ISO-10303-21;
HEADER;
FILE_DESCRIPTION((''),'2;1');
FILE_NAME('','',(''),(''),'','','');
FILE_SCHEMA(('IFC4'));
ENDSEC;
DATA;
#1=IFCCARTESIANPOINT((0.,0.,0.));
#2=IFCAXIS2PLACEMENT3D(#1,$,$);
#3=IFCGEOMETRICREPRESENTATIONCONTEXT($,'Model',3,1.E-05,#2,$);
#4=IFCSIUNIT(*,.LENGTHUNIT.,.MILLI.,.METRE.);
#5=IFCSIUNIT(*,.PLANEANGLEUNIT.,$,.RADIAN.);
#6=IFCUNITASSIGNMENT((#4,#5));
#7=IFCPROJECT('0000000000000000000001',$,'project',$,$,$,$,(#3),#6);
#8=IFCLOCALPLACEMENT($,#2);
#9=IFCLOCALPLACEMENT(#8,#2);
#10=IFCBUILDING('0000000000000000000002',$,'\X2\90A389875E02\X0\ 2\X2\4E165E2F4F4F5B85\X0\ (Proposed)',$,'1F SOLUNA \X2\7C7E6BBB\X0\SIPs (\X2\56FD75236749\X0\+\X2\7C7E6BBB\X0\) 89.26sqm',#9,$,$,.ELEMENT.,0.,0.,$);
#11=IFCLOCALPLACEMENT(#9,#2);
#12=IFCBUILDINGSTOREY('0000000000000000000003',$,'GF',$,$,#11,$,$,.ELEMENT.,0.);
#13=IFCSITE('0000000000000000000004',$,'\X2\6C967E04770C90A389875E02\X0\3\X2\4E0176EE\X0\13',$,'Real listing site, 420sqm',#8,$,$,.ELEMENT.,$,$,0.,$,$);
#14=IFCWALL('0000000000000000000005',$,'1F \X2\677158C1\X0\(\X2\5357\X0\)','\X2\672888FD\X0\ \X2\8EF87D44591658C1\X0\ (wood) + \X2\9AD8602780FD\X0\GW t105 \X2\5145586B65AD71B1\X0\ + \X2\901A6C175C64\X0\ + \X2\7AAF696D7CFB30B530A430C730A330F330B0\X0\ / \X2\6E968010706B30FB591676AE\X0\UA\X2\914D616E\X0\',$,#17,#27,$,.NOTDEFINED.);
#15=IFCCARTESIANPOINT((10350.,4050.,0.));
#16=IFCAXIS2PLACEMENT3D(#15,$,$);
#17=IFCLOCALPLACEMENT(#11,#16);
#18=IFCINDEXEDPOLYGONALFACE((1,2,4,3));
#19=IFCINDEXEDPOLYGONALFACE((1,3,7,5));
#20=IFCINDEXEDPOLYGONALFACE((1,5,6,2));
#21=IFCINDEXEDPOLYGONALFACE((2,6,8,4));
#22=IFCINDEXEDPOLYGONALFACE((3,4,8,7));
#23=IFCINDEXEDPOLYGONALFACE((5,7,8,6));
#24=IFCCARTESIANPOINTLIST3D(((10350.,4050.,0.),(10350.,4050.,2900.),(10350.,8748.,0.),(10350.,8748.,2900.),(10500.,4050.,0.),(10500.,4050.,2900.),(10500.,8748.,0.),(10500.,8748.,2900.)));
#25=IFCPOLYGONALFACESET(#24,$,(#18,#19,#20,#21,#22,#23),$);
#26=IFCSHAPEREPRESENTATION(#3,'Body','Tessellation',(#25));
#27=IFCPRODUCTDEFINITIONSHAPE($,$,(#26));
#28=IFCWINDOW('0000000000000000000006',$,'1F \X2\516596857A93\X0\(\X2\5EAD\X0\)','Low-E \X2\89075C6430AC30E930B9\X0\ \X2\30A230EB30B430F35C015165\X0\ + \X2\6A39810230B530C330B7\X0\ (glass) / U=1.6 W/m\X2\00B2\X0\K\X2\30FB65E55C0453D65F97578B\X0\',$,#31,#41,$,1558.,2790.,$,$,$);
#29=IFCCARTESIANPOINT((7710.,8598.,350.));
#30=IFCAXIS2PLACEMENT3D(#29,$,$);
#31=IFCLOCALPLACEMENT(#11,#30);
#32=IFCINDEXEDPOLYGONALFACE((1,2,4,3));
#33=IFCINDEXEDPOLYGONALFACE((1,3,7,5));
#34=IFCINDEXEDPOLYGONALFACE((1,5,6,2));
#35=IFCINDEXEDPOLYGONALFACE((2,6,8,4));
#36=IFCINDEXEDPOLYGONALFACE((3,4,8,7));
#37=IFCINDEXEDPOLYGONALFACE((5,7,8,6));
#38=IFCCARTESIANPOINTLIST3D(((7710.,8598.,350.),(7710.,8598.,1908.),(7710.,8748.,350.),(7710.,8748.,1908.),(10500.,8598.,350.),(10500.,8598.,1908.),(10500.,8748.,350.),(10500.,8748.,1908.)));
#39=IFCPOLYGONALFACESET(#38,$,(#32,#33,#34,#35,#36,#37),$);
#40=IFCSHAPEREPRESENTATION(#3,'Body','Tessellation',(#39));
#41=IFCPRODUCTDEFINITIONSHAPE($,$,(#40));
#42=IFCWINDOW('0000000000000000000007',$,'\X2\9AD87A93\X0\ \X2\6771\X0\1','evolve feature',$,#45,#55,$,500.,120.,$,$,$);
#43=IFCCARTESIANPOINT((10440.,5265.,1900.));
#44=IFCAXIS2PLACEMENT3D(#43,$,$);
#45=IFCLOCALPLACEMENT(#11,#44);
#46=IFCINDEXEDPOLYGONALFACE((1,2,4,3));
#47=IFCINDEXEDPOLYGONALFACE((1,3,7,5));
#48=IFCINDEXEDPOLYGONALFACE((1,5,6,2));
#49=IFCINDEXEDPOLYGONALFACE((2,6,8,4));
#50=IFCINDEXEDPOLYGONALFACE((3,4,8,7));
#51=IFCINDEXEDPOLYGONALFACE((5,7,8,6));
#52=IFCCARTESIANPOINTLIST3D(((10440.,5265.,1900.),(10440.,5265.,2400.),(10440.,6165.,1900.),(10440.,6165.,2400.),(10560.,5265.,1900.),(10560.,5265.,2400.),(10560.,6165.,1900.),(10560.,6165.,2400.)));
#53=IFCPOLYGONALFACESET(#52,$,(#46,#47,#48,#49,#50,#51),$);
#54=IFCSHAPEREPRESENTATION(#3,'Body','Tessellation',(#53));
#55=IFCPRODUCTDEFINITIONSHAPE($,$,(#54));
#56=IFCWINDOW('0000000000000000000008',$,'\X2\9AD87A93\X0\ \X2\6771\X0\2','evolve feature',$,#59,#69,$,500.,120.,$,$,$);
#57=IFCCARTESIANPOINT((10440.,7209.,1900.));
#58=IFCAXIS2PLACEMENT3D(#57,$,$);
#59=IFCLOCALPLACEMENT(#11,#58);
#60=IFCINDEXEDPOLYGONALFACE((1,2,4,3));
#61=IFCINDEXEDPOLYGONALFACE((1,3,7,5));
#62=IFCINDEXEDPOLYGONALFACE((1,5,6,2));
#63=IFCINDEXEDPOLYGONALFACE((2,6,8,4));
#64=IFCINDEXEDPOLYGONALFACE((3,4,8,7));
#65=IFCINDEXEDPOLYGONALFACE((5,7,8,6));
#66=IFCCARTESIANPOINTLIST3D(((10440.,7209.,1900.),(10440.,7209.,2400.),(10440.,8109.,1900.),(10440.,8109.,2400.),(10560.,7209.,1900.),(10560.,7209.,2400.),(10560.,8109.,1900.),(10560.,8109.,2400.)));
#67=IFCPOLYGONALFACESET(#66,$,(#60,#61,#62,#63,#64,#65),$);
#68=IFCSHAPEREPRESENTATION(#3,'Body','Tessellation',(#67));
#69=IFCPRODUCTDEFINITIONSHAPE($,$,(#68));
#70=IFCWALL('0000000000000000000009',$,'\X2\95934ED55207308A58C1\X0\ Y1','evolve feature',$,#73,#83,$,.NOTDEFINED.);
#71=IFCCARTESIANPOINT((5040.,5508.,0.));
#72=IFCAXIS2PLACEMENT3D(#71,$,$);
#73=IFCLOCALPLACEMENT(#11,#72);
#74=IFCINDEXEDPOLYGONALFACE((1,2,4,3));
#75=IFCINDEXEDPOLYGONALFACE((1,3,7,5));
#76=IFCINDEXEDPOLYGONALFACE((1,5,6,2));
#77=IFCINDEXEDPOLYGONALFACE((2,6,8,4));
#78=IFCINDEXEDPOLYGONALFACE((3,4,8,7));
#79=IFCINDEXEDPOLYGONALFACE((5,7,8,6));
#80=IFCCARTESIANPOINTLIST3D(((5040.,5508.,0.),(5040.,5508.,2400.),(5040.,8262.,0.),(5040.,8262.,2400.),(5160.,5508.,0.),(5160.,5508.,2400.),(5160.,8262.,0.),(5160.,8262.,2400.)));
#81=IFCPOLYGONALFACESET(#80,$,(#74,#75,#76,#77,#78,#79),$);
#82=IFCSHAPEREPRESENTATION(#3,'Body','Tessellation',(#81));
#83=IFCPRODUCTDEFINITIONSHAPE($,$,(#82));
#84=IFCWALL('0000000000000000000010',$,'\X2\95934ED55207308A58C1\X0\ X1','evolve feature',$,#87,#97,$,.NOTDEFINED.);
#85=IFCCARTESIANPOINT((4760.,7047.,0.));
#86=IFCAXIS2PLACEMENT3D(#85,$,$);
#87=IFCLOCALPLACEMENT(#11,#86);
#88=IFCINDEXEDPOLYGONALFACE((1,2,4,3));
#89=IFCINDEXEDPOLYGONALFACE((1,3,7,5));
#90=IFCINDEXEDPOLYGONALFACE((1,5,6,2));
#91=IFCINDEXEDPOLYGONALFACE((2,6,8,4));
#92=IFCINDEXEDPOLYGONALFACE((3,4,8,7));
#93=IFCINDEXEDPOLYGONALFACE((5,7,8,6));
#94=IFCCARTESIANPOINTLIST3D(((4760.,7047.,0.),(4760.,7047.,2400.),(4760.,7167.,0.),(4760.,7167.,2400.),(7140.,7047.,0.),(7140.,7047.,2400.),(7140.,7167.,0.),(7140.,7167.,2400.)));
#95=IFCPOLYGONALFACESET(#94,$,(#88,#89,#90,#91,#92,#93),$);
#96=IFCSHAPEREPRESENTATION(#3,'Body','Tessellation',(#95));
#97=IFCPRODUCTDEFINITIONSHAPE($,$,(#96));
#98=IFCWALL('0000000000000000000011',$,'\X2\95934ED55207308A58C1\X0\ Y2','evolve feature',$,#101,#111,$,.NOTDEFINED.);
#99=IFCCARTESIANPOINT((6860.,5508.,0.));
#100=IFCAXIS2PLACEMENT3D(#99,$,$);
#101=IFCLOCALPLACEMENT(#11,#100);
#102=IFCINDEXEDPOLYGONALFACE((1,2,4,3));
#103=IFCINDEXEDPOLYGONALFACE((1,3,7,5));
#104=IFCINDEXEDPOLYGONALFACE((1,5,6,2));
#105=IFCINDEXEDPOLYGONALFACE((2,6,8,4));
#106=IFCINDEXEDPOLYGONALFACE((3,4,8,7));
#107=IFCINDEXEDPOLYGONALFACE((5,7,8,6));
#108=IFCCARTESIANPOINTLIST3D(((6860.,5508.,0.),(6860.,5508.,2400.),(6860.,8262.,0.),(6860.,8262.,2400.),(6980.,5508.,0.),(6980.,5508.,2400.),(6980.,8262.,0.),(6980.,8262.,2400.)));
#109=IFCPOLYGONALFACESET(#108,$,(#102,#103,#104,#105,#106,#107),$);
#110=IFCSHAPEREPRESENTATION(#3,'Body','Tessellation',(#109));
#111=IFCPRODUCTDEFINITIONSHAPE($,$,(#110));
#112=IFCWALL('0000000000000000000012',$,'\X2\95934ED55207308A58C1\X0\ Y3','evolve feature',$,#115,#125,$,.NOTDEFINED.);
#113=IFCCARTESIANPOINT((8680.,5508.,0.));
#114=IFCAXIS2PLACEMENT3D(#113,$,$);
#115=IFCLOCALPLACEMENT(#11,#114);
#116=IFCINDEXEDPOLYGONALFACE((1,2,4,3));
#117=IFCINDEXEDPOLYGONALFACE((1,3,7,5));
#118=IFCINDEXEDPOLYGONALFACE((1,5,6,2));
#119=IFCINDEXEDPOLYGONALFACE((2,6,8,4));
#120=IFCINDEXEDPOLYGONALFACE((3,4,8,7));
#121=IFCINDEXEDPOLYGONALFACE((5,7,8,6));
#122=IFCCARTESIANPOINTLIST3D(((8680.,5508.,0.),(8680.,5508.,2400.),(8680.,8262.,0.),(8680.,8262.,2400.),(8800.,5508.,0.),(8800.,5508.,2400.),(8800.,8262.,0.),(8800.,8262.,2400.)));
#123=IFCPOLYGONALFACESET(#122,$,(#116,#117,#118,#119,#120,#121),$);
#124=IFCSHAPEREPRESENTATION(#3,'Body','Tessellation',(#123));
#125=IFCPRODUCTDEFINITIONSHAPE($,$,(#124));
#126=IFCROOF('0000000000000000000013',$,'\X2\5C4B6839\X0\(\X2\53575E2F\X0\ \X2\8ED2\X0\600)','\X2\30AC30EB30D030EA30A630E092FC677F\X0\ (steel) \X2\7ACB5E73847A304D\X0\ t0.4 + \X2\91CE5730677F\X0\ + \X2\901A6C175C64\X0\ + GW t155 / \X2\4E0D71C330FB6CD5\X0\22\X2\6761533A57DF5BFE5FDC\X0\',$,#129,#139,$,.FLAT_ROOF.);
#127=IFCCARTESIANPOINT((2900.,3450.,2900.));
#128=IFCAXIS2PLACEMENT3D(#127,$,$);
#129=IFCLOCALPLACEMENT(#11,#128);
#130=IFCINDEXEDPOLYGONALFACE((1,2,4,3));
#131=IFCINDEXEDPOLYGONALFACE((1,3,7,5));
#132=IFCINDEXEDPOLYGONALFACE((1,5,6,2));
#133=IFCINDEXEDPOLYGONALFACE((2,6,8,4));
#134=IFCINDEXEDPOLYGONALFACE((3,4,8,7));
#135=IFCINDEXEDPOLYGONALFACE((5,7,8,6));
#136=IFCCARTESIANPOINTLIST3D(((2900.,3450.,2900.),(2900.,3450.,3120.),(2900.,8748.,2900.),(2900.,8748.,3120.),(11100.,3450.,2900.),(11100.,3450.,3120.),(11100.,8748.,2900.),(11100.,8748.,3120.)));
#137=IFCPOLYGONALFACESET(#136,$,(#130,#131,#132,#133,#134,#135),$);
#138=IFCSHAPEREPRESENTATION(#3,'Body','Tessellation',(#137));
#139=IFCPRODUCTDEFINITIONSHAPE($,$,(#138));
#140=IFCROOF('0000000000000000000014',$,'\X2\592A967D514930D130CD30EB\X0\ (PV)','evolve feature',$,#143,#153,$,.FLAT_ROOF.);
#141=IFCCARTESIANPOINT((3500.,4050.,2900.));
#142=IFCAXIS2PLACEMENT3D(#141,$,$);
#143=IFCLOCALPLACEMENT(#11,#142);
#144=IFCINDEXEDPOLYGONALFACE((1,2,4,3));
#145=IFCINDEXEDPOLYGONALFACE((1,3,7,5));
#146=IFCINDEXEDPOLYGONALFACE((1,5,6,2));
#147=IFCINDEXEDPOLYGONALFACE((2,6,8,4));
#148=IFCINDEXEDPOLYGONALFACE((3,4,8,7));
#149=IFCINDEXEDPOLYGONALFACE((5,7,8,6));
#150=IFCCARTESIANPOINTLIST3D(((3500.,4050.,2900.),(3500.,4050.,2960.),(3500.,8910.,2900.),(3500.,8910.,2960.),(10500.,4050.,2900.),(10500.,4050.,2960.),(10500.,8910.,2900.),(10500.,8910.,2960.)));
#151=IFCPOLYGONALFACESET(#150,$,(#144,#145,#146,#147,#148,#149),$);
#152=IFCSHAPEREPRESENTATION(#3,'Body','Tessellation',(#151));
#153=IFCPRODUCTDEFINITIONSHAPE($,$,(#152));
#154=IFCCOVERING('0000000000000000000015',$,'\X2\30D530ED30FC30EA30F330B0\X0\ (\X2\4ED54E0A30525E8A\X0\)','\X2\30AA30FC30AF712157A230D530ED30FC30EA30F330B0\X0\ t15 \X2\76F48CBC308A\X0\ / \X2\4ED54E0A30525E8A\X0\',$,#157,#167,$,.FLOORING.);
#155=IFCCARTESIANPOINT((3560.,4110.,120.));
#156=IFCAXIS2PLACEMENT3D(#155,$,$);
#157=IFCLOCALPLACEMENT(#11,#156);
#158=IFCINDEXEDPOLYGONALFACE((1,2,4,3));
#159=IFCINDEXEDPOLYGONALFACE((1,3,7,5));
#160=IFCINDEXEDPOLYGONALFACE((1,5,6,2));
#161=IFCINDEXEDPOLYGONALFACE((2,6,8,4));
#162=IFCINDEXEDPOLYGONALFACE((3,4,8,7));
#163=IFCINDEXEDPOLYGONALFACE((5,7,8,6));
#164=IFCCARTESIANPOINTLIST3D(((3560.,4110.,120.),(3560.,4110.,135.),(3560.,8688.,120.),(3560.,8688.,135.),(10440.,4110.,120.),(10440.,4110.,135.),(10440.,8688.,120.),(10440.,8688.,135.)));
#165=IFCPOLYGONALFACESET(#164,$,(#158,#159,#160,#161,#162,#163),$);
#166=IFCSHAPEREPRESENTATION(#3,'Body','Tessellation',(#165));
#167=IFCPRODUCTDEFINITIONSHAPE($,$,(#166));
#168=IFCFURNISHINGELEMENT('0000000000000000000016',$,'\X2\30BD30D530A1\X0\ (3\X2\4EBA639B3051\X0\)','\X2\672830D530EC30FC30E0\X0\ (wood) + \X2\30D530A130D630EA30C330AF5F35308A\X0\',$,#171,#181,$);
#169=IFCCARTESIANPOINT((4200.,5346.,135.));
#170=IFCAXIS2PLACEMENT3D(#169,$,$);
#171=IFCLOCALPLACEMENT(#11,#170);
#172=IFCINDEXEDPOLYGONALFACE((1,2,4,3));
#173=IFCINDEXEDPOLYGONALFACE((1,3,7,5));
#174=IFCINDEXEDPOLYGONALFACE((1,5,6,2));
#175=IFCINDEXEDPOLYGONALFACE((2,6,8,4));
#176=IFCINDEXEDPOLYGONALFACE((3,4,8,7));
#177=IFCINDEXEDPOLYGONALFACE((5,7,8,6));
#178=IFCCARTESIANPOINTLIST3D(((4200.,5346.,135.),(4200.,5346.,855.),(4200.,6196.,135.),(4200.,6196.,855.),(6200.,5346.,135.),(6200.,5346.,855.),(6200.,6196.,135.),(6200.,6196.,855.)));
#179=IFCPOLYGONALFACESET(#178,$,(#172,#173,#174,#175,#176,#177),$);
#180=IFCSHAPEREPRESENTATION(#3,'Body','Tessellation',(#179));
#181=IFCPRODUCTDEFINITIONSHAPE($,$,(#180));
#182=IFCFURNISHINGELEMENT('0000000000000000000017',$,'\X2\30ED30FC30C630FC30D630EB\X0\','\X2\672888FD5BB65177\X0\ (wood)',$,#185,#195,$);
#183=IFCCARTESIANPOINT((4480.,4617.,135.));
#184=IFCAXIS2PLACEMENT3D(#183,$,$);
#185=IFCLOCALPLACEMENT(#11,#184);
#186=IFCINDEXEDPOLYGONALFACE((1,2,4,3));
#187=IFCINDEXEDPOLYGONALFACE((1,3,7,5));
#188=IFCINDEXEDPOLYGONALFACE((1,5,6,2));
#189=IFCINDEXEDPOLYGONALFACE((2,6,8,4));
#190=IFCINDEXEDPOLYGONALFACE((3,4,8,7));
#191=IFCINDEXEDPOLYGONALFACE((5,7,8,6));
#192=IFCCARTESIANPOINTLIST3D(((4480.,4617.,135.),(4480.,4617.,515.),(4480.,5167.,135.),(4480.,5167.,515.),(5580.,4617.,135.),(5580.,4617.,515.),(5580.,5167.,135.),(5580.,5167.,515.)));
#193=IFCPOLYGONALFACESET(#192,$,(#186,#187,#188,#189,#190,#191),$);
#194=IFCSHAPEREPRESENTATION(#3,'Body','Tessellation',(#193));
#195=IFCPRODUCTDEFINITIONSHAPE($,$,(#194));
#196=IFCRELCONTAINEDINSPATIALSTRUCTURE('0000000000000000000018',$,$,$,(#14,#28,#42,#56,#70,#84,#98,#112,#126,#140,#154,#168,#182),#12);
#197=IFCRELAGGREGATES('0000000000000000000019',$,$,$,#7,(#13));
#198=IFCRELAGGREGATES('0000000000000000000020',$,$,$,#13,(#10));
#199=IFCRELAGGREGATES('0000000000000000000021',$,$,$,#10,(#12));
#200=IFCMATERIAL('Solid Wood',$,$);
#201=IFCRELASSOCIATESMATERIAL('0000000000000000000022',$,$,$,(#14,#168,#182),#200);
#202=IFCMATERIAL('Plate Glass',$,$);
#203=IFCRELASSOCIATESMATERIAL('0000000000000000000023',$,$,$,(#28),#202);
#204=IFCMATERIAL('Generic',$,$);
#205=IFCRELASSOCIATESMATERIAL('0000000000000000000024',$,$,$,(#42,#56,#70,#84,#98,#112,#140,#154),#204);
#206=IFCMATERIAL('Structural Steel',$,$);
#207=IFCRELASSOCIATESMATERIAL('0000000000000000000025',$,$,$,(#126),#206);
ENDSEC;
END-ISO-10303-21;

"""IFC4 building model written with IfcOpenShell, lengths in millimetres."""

from ifc_helpers import new_model, si_unit, frame, frame_2d, origin, place, context, project, spatial, rectangle, extrude, material, element, fill, save


model = new_model("IFC4")

# Units and contexts
model_context = context("Model", 3, precision=1e-05, world=origin())
ifc_project = project(units=[si_unit("LENGTHUNIT", "METRE", prefix="MILLI"), si_unit("PLANEANGLEUNIT", "RADIAN")], contexts=[model_context])

# Site, building, storey
site_placement = place(None, origin())
site = spatial("IfcSite", under=ifc_project, at=site_placement, Name="沖縄県那覇市3丁目13", ObjectType="Real listing site, 420sqm", CompositionType="ELEMENT", RefElevation=0.0)
building_placement = place(site_placement, origin())
building = spatial("IfcBuilding", under=site, at=building_placement, Name="那覇市 2世帯住宅 (Proposed)", ObjectType="1F SOLUNA 籾殻SIPs (国産杉+籾殻) 89.26sqm", CompositionType="ELEMENT", ElevationOfRefHeight=0.0, ElevationOfTerrain=0.0)
storey_placement = place(building_placement, origin())
storey = spatial("IfcBuildingStorey", under=building, at=storey_placement, Name="GF", CompositionType="ELEMENT", Elevation=0.0)

# Shared definitions
ifc_material_1 = material(Name="Solid Wood")
ifc_material_2 = material(Name="Generic")

# Shared definitions
ifc_material_3 = material(Name="Plate Glass")

# Wall, openings, windows
wall_1_placement = place(storey_placement, frame((10350.0, 4050.0, 0.0)))
wall_1 = element("IfcWall", 1, at=wall_1_placement, inside=storey, material=ifc_material_1, Name="1F 東壁(南)", Description="木製 軸組外壁 (wood) + 高性能GW t105 充填断熱 + 通気層 + 窯業系サイディング / 準耐火・外皮UA配慮", PredefinedType="NOTDEFINED", context=model_context, shape_type="SweptSolid", body=[
    extrude(rectangle(XDim=150.0, YDim=4698.0, at=frame_2d((75.0, 2349.0))), frame((10350.0, 4050.0, 0.0)), (0.0, 0.0, 1.0), 2900.0),
])
opening_1_placement = place(storey_placement, frame((7710.0, 8598.0, 350.0)))
opening_1 = element("IfcOpeningElement", 2, at=opening_1_placement, cuts=wall_1, PredefinedType="NOTDEFINED", context=model_context, shape_type="SweptSolid", body=[
    extrude(rectangle(XDim=2790.0, YDim=150.0, at=frame_2d((1395.0, 75.0))), frame((7710.0, 8598.0, 350.0)), (0.0, 0.0, 1.0), 1558.0),
])
opening_2_placement = place(storey_placement, frame((10440.0, 5265.0, 1900.0)))
opening_2 = element("IfcOpeningElement", 3, at=opening_2_placement, cuts=wall_1, PredefinedType="NOTDEFINED", context=model_context, shape_type="SweptSolid", body=[
    extrude(rectangle(XDim=120.0, YDim=900.0, at=frame_2d((60.0, 450.0))), frame((10440.0, 5265.0, 1900.0)), (0.0, 0.0, 1.0), 500.0),
])
opening_3_placement = place(storey_placement, frame((10440.0, 7209.0, 1900.0)))
opening_3 = element("IfcOpeningElement", 4, at=opening_3_placement, cuts=wall_1, PredefinedType="NOTDEFINED", context=model_context, shape_type="SweptSolid", body=[
    extrude(rectangle(XDim=120.0, YDim=900.0, at=frame_2d((60.0, 450.0))), frame((10440.0, 7209.0, 1900.0)), (0.0, 0.0, 1.0), 500.0),
])
window_1_placement = place(storey_placement, frame((7710.0, 8598.0, 350.0)))
window_1 = element("IfcWindow", 5, at=window_1_placement, inside=storey, material=ifc_material_3, Name="1F 入隅窓(庭)", Description="Low-E 複層ガラス アルゴン封入 + 樹脂サッシ (glass) / U=1.6 W/m²K・日射取得型", OverallHeight=1558.0, OverallWidth=2790.0, context=model_context, shape_type="SweptSolid", body=[
    extrude(rectangle(XDim=2790.0, YDim=150.0, at=frame_2d((1395.0, 75.0))), frame((7710.0, 8598.0, 350.0)), (0.0, 0.0, 1.0), 1558.0),
])
fill(opening_1, window_1)
window_2_placement = place(storey_placement, frame((10440.0, 5265.0, 1900.0)))
window_2 = element("IfcWindow", 6, at=window_2_placement, inside=storey, material=ifc_material_2, Name="高窓 東1", Description="evolve feature", OverallHeight=500.0, OverallWidth=120.0, context=model_context, shape_type="SweptSolid", body=[
    extrude(rectangle(XDim=120.0, YDim=900.0, at=frame_2d((60.0, 450.0))), frame((10440.0, 5265.0, 1900.0)), (0.0, 0.0, 1.0), 500.0),
])
fill(opening_2, window_2)
window_3_placement = place(storey_placement, frame((10440.0, 7209.0, 1900.0)))
window_3 = element("IfcWindow", 7, at=window_3_placement, inside=storey, material=ifc_material_2, Name="高窓 東2", Description="evolve feature", OverallHeight=500.0, OverallWidth=120.0, context=model_context, shape_type="SweptSolid", body=[
    extrude(rectangle(XDim=120.0, YDim=900.0, at=frame_2d((60.0, 450.0))), frame((10440.0, 7209.0, 1900.0)), (0.0, 0.0, 1.0), 500.0),
])
fill(opening_3, window_3)

# Walls
wall_2_placement = place(storey_placement, frame((5040.0, 5508.0, 0.0)))
element("IfcWall", 8, at=wall_2_placement, inside=storey, material=ifc_material_2, Name="間仕切り壁 Y1", Description="evolve feature", PredefinedType="NOTDEFINED", context=model_context, shape_type="SweptSolid", body=[
    extrude(rectangle(XDim=120.0, YDim=2754.0, at=frame_2d((60.0, 1377.0))), frame((5040.0, 5508.0, 0.0)), (0.0, 0.0, 1.0), 2400.0),
])
wall_3_placement = place(storey_placement, frame((4760.0, 7047.0, 0.0)))
element("IfcWall", 9, at=wall_3_placement, inside=storey, material=ifc_material_2, Name="間仕切り壁 X1", Description="evolve feature", PredefinedType="NOTDEFINED", context=model_context, shape_type="SweptSolid", body=[
    extrude(rectangle(XDim=2380.0, YDim=120.0, at=frame_2d((1190.0, 60.0))), frame((4760.0, 7047.0, 0.0)), (0.0, 0.0, 1.0), 2400.0),
])
wall_4_placement = place(storey_placement, frame((6860.0, 5508.0, 0.0)))
element("IfcWall", 10, at=wall_4_placement, inside=storey, material=ifc_material_2, Name="間仕切り壁 Y2", Description="evolve feature", PredefinedType="NOTDEFINED", context=model_context, shape_type="SweptSolid", body=[
    extrude(rectangle(XDim=120.0, YDim=2754.0, at=frame_2d((60.0, 1377.0))), frame((6860.0, 5508.0, 0.0)), (0.0, 0.0, 1.0), 2400.0),
])
wall_5_placement = place(storey_placement, frame((8680.0, 5508.0, 0.0)))
element("IfcWall", 11, at=wall_5_placement, inside=storey, material=ifc_material_2, Name="間仕切り壁 Y3", Description="evolve feature", PredefinedType="NOTDEFINED", context=model_context, shape_type="SweptSolid", body=[
    extrude(rectangle(XDim=120.0, YDim=2754.0, at=frame_2d((60.0, 1377.0))), frame((8680.0, 5508.0, 0.0)), (0.0, 0.0, 1.0), 2400.0),
])

# Roofs
ifc_material_4 = material(Name="Structural Steel")
roof_1_placement = place(storey_placement, frame((2900.0, 3450.0, 2900.0)))
element("IfcRoof", 12, at=roof_1_placement, inside=storey, material=ifc_material_4, Name="屋根(南帯 軒600)", Description="ガルバリウム鋼板 (steel) 立平葺き t0.4 + 野地板 + 通気層 + GW t155 / 不燃・法22条区域対応", PredefinedType="FLAT_ROOF", context=model_context, shape_type="SweptSolid", body=[
    extrude(rectangle(XDim=8200.0, YDim=5298.0, at=frame_2d((4100.0, 2649.0))), frame((2900.0, 3450.0, 2900.0)), (0.0, 0.0, 1.0), 220.0),
])
roof_2_placement = place(storey_placement, frame((3500.0, 4050.0, 2900.0)))
element("IfcRoof", 13, at=roof_2_placement, inside=storey, material=ifc_material_2, Name="太陽光パネル (PV)", Description="evolve feature", PredefinedType="FLAT_ROOF", context=model_context, shape_type="SweptSolid", body=[
    extrude(rectangle(XDim=7000.0, YDim=4860.0, at=frame_2d((3500.0, 2430.0))), frame((3500.0, 4050.0, 2900.0)), (0.0, 0.0, 1.0), 60.0),
])

# Covering
covering_placement = place(storey_placement, frame((3560.0, 4110.0, 120.0)))
element("IfcCovering", 14, at=covering_placement, inside=storey, material=ifc_material_2, Name="フローリング (仕上げ床)", Description="オーク無垢フローリング t15 直貼り / 仕上げ床", PredefinedType="FLOORING", context=model_context, shape_type="SweptSolid", body=[
    extrude(rectangle(XDim=6880.0, YDim=4578.0, at=frame_2d((3440.0, 2289.0))), frame((3560.0, 4110.0, 120.0)), (0.0, 0.0, 1.0), 15.0),
])

# Furnishing elements
furnishing_1_placement = place(storey_placement, frame((4200.0, 5346.0, 135.0)))
element("IfcFurnishingElement", 15, at=furnishing_1_placement, inside=storey, material=ifc_material_1, Name="ソファ (3人掛け)", Description="木フレーム (wood) + ファブリック張り", context=model_context, shape_type="SweptSolid", body=[
    extrude(rectangle(XDim=2000.0, YDim=850.0, at=frame_2d((1000.0, 425.0))), frame((4200.0, 5346.0, 135.0)), (0.0, 0.0, 1.0), 720.0),
])
furnishing_2_placement = place(storey_placement, frame((4480.0, 4617.0, 135.0)))
element("IfcFurnishingElement", 16, at=furnishing_2_placement, inside=storey, material=ifc_material_1, Name="ローテーブル", Description="木製家具 (wood)", context=model_context, shape_type="SweptSolid", body=[
    extrude(rectangle(XDim=1100.0, YDim=550.0, at=frame_2d((550.0, 275.0))), frame((4480.0, 4617.0, 135.0)), (0.0, 0.0, 1.0), 380.0),
])

save(model, "model.ifc")
